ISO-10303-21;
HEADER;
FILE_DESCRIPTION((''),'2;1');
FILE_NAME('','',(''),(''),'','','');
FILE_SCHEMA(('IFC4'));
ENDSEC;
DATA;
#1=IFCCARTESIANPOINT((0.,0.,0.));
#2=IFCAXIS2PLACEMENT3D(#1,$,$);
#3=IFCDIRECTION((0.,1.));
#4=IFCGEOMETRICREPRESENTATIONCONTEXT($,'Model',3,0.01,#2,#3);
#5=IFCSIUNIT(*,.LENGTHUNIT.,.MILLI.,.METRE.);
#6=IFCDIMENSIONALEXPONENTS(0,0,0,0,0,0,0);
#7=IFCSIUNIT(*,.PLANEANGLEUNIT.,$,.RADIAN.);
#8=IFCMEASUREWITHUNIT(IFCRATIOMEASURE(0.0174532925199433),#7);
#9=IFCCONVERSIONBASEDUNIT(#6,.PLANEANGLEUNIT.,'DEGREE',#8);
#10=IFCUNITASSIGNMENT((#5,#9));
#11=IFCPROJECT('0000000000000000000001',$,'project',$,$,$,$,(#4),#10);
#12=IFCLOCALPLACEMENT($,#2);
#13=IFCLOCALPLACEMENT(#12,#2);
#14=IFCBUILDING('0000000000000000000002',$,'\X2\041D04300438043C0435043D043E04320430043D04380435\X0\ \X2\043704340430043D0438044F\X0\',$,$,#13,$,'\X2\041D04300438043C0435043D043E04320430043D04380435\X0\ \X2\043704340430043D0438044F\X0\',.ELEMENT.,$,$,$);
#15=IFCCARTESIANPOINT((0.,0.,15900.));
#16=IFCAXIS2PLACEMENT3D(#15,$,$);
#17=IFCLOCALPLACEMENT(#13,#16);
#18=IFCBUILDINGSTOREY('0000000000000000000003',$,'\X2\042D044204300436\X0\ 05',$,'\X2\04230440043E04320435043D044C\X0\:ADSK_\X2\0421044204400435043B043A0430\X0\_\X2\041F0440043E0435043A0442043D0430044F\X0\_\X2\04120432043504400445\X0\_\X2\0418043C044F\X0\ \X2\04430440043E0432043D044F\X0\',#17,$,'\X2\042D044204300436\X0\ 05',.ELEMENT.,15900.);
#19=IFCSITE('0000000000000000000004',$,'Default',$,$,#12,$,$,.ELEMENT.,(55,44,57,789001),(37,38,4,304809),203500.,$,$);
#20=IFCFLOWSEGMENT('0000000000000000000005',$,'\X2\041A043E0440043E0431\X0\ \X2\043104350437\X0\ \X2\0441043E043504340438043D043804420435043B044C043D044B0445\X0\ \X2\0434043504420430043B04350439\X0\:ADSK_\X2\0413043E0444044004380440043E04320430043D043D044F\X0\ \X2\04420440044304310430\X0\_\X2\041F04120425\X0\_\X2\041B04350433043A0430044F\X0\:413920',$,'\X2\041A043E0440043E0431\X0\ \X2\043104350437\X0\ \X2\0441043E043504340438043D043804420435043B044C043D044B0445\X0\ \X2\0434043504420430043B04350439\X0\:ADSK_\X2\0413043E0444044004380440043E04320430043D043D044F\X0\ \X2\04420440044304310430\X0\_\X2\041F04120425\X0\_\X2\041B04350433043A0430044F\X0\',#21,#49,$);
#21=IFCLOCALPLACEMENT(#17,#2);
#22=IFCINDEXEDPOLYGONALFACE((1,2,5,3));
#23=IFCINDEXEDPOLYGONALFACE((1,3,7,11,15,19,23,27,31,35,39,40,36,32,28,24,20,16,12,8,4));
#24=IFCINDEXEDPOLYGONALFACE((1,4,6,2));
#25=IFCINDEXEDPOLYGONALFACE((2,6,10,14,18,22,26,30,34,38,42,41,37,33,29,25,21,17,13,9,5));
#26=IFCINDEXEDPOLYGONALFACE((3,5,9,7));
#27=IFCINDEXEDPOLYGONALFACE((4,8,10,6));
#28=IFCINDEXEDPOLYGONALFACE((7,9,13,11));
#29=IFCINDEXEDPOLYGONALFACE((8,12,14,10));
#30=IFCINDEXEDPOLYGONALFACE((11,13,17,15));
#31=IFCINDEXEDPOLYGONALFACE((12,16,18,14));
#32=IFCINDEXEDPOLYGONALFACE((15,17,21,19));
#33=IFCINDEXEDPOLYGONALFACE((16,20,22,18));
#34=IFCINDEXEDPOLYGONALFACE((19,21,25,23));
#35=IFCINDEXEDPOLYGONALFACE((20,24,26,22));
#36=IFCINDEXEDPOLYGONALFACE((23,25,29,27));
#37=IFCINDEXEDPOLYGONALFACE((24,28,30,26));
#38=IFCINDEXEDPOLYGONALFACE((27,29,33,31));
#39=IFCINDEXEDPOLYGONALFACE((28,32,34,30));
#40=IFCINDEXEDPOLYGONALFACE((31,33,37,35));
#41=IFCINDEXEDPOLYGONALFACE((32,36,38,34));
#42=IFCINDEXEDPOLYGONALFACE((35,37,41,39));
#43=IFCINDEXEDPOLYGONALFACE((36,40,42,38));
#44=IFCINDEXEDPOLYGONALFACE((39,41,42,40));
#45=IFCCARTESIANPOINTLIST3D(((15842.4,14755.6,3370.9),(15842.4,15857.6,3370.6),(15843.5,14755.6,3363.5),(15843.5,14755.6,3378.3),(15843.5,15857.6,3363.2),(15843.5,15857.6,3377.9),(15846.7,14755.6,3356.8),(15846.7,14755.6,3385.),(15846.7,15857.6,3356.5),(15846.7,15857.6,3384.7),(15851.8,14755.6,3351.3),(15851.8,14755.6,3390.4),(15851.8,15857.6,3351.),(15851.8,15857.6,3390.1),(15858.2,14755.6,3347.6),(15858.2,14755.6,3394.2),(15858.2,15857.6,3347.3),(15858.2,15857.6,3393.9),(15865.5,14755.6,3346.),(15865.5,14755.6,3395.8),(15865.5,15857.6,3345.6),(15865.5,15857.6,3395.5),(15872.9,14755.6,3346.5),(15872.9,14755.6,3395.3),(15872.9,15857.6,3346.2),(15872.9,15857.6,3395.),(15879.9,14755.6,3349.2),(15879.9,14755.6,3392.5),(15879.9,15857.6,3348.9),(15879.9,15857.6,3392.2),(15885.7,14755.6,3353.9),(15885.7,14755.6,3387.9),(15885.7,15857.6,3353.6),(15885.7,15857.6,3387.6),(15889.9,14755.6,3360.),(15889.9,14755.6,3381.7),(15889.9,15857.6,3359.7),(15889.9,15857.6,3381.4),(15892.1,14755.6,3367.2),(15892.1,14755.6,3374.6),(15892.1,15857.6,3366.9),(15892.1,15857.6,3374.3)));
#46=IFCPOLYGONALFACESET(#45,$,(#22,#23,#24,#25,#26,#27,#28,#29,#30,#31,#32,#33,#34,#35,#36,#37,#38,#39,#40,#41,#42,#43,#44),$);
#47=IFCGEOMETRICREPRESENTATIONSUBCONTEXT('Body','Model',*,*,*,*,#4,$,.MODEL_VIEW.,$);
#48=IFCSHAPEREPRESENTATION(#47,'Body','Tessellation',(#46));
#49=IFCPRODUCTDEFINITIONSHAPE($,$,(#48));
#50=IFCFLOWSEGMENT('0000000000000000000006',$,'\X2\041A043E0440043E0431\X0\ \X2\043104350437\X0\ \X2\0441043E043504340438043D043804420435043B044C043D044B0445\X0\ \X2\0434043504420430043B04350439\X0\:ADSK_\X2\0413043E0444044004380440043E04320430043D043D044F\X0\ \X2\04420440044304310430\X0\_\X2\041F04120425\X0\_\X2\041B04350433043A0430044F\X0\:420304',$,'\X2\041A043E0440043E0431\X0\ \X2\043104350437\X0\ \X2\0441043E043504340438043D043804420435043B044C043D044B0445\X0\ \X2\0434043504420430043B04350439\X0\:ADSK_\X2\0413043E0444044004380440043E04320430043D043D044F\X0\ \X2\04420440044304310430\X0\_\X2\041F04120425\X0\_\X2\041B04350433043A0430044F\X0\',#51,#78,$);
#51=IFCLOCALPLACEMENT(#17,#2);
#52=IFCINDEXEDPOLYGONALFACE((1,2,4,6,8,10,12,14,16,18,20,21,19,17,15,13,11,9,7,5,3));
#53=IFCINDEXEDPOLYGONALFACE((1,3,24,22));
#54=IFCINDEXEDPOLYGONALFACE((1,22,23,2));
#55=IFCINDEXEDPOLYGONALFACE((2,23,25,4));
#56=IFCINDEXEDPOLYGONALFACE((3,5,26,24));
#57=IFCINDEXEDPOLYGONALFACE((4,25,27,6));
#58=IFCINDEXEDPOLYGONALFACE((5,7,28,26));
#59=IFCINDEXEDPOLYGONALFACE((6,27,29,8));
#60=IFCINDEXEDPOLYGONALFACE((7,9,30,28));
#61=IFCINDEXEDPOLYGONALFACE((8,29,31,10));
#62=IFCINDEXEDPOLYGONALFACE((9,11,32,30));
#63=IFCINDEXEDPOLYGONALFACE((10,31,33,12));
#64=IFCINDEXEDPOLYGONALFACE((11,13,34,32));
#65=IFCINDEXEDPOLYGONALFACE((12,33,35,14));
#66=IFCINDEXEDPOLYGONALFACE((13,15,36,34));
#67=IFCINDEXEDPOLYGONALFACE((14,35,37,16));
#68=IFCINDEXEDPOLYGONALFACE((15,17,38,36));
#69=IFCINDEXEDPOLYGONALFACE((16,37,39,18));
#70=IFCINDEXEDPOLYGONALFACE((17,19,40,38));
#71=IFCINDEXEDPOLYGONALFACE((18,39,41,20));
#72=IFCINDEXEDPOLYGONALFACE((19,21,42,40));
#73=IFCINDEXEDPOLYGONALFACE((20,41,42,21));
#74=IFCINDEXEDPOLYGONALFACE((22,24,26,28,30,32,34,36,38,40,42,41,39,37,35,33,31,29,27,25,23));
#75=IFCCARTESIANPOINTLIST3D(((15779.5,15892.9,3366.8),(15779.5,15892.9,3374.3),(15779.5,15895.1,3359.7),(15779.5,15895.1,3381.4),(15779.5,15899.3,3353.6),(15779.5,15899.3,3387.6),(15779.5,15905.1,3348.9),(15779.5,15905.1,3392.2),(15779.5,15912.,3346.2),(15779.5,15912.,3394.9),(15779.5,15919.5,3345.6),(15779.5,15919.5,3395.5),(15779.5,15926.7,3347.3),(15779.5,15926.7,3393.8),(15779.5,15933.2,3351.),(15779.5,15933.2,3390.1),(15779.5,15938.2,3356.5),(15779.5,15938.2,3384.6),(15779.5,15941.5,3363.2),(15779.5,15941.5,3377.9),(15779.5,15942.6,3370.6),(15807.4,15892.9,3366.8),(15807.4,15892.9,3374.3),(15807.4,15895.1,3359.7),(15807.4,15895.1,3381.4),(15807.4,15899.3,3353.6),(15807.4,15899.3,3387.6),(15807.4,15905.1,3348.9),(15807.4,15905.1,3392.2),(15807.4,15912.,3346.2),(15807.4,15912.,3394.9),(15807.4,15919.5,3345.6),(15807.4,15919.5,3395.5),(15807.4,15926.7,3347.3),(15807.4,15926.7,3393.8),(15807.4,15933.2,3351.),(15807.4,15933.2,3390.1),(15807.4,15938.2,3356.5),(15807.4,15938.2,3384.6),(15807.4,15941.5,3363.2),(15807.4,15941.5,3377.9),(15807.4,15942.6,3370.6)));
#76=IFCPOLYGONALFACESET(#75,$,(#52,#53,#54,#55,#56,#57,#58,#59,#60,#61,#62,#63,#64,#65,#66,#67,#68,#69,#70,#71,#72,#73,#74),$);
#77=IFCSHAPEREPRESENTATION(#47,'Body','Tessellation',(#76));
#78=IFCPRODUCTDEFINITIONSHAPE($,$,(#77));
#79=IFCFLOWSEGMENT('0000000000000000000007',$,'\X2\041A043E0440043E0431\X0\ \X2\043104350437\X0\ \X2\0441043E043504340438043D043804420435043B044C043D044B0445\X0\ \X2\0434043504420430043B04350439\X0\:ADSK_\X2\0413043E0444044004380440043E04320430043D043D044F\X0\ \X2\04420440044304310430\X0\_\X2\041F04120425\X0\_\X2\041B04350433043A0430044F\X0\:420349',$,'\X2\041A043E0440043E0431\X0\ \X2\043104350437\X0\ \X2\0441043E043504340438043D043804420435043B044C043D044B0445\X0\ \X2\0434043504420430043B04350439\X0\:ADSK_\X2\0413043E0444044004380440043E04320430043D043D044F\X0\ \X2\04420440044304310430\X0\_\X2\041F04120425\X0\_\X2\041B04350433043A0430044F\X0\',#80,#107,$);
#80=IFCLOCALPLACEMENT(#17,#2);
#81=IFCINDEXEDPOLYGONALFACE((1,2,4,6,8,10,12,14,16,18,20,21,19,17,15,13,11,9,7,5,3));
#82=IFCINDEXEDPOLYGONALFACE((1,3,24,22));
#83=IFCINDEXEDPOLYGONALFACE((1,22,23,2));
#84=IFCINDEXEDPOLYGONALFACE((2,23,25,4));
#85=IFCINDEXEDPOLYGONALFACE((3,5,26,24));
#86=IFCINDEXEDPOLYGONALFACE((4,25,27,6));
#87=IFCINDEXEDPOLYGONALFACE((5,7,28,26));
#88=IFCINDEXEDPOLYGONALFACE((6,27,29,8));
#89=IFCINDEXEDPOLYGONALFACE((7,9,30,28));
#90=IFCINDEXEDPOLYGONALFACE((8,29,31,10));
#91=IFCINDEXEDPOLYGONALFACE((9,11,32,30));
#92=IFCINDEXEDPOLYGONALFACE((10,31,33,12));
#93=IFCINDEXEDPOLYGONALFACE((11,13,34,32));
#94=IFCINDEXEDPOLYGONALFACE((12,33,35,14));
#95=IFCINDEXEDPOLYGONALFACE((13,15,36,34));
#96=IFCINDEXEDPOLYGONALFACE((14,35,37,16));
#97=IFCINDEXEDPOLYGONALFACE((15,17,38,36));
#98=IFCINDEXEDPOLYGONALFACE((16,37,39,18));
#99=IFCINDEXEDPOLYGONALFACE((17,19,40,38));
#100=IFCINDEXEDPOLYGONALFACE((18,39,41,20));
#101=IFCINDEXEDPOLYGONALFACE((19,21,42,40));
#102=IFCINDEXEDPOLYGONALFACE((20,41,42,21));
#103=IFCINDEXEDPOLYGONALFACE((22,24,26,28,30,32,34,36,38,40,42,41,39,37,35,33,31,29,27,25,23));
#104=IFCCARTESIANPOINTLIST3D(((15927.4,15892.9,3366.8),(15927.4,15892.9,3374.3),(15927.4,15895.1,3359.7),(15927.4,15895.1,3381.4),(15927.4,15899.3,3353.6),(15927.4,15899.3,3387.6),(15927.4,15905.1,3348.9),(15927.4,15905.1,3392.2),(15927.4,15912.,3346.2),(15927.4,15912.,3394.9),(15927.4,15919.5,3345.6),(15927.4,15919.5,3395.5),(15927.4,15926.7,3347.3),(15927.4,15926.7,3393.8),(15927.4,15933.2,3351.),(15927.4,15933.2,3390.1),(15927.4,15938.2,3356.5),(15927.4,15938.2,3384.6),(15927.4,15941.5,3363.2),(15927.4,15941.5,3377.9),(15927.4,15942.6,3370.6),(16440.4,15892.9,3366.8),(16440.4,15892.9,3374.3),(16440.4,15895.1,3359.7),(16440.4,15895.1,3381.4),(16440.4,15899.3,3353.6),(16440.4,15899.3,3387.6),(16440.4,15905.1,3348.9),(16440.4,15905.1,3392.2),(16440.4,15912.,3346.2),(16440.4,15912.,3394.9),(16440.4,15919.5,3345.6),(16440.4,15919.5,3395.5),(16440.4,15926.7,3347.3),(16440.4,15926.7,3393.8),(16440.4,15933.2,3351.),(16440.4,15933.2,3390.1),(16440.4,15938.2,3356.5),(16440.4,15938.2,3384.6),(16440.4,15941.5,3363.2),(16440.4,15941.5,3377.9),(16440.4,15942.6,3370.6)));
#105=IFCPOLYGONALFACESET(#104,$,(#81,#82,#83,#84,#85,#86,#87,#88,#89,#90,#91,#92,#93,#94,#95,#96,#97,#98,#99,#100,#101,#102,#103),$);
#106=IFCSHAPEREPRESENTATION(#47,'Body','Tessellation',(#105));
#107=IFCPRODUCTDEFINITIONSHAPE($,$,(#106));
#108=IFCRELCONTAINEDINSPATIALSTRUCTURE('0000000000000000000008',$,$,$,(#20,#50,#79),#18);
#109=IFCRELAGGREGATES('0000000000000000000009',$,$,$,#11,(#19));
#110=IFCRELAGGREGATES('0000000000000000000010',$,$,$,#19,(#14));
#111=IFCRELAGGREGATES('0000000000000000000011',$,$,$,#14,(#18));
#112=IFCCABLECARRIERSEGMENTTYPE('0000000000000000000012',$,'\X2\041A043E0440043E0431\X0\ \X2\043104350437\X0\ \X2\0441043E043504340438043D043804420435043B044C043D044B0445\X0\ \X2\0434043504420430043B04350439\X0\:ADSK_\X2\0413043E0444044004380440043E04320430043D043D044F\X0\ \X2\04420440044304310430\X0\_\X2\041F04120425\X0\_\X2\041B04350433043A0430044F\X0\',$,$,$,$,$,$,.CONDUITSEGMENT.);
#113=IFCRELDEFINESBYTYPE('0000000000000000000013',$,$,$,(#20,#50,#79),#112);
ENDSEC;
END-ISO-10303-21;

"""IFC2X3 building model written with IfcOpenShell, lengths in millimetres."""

from ifc_helpers import new_model, entity, si_unit, converted_unit, direction, frame, frame_2d, origin, origin_2d_with_axis, place, context, subcontext, project, spatial, circle, extrude, type_object, element, save


model = new_model("IFC2X3")

# Units and contexts
model_context = context("Model", 3, precision=0.01, world=origin(), true_north=direction((0.0, 1.0)))
body_context = subcontext(model_context, "Body", "Model", "MODEL_VIEW")
ifc_project = project(units=[si_unit("LENGTHUNIT", "METRE", prefix="MILLI"), converted_unit("PLANEANGLEUNIT", "DEGREE", entity("IfcRatioMeasure", 0.0174532925199433), si_unit("PLANEANGLEUNIT", "RADIAN"), dimensions=[0, 0, 0, 0, 0, 0, 0])], contexts=[model_context])

# Site, building, storey
site_placement = place(None, frame((0.0, 0.0, 0.0)))
site = spatial("IfcSite", under=ifc_project, at=site_placement, Name="Default", CompositionType="ELEMENT", RefLatitude=(55, 44, 57, 789001), RefLongitude=(37, 38, 4, 304809), RefElevation=203500.0)
building_placement = place(site_placement, origin())
building = spatial("IfcBuilding", under=site, at=building_placement, Name="Наименование здания", LongName="Наименование здания", CompositionType="ELEMENT")
storey_placement = place(building_placement, frame((0.0, 0.0, 15900.0)))
storey = spatial("IfcBuildingStorey", under=building, at=storey_placement, Name="Этаж 05", ObjectType="Уровень:ADSK_Стрелка_Проектная_Вверх_Имя уровня", LongName="Этаж 05", CompositionType="ELEMENT", Elevation=15900.0)

# Flow segments
cable_carrier_segment_type = type_object("IfcCableCarrierSegmentType", Name="Короб без соединительных деталей:ADSK_Гофрировання труба_ПВХ_Легкая", PredefinedType="CONDUITSEGMENT")
flow_segment_1_placement = place(storey_placement, frame((15840.8, 14755.6, 3344.0)))
element("IfcFlowSegment", 1, at=flow_segment_1_placement, inside=storey, type_object=cable_carrier_segment_type, Name="Короб без соединительных деталей:ADSK_Гофрировання труба_ПВХ_Легкая:413920", ObjectType="Короб без соединительных деталей:ADSK_Гофрировання труба_ПВХ_Легкая", context=body_context, shape_type="SweptSolid", body=[
    extrude(circle(Radius=25.0, at=origin_2d_with_axis()), frame((26.6, 1102.0, 26.6), z_axis=(0.000002, -1.0, 0.000285), x_axis=(-1.0, -0.000002, 0.0)), (0.0, 0.0, 1.0), 1102.0),
])
flow_segment_2_placement = place(storey_placement, frame((15779.5, 15891.0, 3344.0)))
element("IfcFlowSegment", 2, at=flow_segment_2_placement, inside=storey, type_object=cable_carrier_segment_type, Name="Короб без соединительных деталей:ADSK_Гофрировання труба_ПВХ_Легкая:420304", ObjectType="Короб без соединительных деталей:ADSK_Гофрировання труба_ПВХ_Легкая", context=body_context, shape_type="SweptSolid", body=[
    extrude(circle(Radius=25.0, at=frame_2d((0.0, 0.0), x_axis=(1.0, 0.0))), frame((0.0, 26.6, 26.6), z_axis=(1.0, -0.000002, 0.0), x_axis=(0.000002, 1.0, 0.0)), (0.0, 0.0, 1.0), 27.9),
])
flow_segment_3_placement = place(storey_placement, frame((15927.4, 15891.0, 3344.0)))
element("IfcFlowSegment", 3, at=flow_segment_3_placement, inside=storey, type_object=cable_carrier_segment_type, Name="Короб без соединительных деталей:ADSK_Гофрировання труба_ПВХ_Легкая:420349", ObjectType="Короб без соединительных деталей:ADSK_Гофрировання труба_ПВХ_Легкая", context=body_context, shape_type="SweptSolid", body=[
    extrude(circle(Radius=25.0, at=frame_2d((0.0, 0.0), x_axis=(1.0, 0.0))), frame((0.0, 26.6, 26.6), z_axis=(1.0, -0.000002, 0.0), x_axis=(0.000002, 1.0, 0.0)), (0.0, 0.0, 1.0), 513.0),
])

save(model, "model.ifc")
